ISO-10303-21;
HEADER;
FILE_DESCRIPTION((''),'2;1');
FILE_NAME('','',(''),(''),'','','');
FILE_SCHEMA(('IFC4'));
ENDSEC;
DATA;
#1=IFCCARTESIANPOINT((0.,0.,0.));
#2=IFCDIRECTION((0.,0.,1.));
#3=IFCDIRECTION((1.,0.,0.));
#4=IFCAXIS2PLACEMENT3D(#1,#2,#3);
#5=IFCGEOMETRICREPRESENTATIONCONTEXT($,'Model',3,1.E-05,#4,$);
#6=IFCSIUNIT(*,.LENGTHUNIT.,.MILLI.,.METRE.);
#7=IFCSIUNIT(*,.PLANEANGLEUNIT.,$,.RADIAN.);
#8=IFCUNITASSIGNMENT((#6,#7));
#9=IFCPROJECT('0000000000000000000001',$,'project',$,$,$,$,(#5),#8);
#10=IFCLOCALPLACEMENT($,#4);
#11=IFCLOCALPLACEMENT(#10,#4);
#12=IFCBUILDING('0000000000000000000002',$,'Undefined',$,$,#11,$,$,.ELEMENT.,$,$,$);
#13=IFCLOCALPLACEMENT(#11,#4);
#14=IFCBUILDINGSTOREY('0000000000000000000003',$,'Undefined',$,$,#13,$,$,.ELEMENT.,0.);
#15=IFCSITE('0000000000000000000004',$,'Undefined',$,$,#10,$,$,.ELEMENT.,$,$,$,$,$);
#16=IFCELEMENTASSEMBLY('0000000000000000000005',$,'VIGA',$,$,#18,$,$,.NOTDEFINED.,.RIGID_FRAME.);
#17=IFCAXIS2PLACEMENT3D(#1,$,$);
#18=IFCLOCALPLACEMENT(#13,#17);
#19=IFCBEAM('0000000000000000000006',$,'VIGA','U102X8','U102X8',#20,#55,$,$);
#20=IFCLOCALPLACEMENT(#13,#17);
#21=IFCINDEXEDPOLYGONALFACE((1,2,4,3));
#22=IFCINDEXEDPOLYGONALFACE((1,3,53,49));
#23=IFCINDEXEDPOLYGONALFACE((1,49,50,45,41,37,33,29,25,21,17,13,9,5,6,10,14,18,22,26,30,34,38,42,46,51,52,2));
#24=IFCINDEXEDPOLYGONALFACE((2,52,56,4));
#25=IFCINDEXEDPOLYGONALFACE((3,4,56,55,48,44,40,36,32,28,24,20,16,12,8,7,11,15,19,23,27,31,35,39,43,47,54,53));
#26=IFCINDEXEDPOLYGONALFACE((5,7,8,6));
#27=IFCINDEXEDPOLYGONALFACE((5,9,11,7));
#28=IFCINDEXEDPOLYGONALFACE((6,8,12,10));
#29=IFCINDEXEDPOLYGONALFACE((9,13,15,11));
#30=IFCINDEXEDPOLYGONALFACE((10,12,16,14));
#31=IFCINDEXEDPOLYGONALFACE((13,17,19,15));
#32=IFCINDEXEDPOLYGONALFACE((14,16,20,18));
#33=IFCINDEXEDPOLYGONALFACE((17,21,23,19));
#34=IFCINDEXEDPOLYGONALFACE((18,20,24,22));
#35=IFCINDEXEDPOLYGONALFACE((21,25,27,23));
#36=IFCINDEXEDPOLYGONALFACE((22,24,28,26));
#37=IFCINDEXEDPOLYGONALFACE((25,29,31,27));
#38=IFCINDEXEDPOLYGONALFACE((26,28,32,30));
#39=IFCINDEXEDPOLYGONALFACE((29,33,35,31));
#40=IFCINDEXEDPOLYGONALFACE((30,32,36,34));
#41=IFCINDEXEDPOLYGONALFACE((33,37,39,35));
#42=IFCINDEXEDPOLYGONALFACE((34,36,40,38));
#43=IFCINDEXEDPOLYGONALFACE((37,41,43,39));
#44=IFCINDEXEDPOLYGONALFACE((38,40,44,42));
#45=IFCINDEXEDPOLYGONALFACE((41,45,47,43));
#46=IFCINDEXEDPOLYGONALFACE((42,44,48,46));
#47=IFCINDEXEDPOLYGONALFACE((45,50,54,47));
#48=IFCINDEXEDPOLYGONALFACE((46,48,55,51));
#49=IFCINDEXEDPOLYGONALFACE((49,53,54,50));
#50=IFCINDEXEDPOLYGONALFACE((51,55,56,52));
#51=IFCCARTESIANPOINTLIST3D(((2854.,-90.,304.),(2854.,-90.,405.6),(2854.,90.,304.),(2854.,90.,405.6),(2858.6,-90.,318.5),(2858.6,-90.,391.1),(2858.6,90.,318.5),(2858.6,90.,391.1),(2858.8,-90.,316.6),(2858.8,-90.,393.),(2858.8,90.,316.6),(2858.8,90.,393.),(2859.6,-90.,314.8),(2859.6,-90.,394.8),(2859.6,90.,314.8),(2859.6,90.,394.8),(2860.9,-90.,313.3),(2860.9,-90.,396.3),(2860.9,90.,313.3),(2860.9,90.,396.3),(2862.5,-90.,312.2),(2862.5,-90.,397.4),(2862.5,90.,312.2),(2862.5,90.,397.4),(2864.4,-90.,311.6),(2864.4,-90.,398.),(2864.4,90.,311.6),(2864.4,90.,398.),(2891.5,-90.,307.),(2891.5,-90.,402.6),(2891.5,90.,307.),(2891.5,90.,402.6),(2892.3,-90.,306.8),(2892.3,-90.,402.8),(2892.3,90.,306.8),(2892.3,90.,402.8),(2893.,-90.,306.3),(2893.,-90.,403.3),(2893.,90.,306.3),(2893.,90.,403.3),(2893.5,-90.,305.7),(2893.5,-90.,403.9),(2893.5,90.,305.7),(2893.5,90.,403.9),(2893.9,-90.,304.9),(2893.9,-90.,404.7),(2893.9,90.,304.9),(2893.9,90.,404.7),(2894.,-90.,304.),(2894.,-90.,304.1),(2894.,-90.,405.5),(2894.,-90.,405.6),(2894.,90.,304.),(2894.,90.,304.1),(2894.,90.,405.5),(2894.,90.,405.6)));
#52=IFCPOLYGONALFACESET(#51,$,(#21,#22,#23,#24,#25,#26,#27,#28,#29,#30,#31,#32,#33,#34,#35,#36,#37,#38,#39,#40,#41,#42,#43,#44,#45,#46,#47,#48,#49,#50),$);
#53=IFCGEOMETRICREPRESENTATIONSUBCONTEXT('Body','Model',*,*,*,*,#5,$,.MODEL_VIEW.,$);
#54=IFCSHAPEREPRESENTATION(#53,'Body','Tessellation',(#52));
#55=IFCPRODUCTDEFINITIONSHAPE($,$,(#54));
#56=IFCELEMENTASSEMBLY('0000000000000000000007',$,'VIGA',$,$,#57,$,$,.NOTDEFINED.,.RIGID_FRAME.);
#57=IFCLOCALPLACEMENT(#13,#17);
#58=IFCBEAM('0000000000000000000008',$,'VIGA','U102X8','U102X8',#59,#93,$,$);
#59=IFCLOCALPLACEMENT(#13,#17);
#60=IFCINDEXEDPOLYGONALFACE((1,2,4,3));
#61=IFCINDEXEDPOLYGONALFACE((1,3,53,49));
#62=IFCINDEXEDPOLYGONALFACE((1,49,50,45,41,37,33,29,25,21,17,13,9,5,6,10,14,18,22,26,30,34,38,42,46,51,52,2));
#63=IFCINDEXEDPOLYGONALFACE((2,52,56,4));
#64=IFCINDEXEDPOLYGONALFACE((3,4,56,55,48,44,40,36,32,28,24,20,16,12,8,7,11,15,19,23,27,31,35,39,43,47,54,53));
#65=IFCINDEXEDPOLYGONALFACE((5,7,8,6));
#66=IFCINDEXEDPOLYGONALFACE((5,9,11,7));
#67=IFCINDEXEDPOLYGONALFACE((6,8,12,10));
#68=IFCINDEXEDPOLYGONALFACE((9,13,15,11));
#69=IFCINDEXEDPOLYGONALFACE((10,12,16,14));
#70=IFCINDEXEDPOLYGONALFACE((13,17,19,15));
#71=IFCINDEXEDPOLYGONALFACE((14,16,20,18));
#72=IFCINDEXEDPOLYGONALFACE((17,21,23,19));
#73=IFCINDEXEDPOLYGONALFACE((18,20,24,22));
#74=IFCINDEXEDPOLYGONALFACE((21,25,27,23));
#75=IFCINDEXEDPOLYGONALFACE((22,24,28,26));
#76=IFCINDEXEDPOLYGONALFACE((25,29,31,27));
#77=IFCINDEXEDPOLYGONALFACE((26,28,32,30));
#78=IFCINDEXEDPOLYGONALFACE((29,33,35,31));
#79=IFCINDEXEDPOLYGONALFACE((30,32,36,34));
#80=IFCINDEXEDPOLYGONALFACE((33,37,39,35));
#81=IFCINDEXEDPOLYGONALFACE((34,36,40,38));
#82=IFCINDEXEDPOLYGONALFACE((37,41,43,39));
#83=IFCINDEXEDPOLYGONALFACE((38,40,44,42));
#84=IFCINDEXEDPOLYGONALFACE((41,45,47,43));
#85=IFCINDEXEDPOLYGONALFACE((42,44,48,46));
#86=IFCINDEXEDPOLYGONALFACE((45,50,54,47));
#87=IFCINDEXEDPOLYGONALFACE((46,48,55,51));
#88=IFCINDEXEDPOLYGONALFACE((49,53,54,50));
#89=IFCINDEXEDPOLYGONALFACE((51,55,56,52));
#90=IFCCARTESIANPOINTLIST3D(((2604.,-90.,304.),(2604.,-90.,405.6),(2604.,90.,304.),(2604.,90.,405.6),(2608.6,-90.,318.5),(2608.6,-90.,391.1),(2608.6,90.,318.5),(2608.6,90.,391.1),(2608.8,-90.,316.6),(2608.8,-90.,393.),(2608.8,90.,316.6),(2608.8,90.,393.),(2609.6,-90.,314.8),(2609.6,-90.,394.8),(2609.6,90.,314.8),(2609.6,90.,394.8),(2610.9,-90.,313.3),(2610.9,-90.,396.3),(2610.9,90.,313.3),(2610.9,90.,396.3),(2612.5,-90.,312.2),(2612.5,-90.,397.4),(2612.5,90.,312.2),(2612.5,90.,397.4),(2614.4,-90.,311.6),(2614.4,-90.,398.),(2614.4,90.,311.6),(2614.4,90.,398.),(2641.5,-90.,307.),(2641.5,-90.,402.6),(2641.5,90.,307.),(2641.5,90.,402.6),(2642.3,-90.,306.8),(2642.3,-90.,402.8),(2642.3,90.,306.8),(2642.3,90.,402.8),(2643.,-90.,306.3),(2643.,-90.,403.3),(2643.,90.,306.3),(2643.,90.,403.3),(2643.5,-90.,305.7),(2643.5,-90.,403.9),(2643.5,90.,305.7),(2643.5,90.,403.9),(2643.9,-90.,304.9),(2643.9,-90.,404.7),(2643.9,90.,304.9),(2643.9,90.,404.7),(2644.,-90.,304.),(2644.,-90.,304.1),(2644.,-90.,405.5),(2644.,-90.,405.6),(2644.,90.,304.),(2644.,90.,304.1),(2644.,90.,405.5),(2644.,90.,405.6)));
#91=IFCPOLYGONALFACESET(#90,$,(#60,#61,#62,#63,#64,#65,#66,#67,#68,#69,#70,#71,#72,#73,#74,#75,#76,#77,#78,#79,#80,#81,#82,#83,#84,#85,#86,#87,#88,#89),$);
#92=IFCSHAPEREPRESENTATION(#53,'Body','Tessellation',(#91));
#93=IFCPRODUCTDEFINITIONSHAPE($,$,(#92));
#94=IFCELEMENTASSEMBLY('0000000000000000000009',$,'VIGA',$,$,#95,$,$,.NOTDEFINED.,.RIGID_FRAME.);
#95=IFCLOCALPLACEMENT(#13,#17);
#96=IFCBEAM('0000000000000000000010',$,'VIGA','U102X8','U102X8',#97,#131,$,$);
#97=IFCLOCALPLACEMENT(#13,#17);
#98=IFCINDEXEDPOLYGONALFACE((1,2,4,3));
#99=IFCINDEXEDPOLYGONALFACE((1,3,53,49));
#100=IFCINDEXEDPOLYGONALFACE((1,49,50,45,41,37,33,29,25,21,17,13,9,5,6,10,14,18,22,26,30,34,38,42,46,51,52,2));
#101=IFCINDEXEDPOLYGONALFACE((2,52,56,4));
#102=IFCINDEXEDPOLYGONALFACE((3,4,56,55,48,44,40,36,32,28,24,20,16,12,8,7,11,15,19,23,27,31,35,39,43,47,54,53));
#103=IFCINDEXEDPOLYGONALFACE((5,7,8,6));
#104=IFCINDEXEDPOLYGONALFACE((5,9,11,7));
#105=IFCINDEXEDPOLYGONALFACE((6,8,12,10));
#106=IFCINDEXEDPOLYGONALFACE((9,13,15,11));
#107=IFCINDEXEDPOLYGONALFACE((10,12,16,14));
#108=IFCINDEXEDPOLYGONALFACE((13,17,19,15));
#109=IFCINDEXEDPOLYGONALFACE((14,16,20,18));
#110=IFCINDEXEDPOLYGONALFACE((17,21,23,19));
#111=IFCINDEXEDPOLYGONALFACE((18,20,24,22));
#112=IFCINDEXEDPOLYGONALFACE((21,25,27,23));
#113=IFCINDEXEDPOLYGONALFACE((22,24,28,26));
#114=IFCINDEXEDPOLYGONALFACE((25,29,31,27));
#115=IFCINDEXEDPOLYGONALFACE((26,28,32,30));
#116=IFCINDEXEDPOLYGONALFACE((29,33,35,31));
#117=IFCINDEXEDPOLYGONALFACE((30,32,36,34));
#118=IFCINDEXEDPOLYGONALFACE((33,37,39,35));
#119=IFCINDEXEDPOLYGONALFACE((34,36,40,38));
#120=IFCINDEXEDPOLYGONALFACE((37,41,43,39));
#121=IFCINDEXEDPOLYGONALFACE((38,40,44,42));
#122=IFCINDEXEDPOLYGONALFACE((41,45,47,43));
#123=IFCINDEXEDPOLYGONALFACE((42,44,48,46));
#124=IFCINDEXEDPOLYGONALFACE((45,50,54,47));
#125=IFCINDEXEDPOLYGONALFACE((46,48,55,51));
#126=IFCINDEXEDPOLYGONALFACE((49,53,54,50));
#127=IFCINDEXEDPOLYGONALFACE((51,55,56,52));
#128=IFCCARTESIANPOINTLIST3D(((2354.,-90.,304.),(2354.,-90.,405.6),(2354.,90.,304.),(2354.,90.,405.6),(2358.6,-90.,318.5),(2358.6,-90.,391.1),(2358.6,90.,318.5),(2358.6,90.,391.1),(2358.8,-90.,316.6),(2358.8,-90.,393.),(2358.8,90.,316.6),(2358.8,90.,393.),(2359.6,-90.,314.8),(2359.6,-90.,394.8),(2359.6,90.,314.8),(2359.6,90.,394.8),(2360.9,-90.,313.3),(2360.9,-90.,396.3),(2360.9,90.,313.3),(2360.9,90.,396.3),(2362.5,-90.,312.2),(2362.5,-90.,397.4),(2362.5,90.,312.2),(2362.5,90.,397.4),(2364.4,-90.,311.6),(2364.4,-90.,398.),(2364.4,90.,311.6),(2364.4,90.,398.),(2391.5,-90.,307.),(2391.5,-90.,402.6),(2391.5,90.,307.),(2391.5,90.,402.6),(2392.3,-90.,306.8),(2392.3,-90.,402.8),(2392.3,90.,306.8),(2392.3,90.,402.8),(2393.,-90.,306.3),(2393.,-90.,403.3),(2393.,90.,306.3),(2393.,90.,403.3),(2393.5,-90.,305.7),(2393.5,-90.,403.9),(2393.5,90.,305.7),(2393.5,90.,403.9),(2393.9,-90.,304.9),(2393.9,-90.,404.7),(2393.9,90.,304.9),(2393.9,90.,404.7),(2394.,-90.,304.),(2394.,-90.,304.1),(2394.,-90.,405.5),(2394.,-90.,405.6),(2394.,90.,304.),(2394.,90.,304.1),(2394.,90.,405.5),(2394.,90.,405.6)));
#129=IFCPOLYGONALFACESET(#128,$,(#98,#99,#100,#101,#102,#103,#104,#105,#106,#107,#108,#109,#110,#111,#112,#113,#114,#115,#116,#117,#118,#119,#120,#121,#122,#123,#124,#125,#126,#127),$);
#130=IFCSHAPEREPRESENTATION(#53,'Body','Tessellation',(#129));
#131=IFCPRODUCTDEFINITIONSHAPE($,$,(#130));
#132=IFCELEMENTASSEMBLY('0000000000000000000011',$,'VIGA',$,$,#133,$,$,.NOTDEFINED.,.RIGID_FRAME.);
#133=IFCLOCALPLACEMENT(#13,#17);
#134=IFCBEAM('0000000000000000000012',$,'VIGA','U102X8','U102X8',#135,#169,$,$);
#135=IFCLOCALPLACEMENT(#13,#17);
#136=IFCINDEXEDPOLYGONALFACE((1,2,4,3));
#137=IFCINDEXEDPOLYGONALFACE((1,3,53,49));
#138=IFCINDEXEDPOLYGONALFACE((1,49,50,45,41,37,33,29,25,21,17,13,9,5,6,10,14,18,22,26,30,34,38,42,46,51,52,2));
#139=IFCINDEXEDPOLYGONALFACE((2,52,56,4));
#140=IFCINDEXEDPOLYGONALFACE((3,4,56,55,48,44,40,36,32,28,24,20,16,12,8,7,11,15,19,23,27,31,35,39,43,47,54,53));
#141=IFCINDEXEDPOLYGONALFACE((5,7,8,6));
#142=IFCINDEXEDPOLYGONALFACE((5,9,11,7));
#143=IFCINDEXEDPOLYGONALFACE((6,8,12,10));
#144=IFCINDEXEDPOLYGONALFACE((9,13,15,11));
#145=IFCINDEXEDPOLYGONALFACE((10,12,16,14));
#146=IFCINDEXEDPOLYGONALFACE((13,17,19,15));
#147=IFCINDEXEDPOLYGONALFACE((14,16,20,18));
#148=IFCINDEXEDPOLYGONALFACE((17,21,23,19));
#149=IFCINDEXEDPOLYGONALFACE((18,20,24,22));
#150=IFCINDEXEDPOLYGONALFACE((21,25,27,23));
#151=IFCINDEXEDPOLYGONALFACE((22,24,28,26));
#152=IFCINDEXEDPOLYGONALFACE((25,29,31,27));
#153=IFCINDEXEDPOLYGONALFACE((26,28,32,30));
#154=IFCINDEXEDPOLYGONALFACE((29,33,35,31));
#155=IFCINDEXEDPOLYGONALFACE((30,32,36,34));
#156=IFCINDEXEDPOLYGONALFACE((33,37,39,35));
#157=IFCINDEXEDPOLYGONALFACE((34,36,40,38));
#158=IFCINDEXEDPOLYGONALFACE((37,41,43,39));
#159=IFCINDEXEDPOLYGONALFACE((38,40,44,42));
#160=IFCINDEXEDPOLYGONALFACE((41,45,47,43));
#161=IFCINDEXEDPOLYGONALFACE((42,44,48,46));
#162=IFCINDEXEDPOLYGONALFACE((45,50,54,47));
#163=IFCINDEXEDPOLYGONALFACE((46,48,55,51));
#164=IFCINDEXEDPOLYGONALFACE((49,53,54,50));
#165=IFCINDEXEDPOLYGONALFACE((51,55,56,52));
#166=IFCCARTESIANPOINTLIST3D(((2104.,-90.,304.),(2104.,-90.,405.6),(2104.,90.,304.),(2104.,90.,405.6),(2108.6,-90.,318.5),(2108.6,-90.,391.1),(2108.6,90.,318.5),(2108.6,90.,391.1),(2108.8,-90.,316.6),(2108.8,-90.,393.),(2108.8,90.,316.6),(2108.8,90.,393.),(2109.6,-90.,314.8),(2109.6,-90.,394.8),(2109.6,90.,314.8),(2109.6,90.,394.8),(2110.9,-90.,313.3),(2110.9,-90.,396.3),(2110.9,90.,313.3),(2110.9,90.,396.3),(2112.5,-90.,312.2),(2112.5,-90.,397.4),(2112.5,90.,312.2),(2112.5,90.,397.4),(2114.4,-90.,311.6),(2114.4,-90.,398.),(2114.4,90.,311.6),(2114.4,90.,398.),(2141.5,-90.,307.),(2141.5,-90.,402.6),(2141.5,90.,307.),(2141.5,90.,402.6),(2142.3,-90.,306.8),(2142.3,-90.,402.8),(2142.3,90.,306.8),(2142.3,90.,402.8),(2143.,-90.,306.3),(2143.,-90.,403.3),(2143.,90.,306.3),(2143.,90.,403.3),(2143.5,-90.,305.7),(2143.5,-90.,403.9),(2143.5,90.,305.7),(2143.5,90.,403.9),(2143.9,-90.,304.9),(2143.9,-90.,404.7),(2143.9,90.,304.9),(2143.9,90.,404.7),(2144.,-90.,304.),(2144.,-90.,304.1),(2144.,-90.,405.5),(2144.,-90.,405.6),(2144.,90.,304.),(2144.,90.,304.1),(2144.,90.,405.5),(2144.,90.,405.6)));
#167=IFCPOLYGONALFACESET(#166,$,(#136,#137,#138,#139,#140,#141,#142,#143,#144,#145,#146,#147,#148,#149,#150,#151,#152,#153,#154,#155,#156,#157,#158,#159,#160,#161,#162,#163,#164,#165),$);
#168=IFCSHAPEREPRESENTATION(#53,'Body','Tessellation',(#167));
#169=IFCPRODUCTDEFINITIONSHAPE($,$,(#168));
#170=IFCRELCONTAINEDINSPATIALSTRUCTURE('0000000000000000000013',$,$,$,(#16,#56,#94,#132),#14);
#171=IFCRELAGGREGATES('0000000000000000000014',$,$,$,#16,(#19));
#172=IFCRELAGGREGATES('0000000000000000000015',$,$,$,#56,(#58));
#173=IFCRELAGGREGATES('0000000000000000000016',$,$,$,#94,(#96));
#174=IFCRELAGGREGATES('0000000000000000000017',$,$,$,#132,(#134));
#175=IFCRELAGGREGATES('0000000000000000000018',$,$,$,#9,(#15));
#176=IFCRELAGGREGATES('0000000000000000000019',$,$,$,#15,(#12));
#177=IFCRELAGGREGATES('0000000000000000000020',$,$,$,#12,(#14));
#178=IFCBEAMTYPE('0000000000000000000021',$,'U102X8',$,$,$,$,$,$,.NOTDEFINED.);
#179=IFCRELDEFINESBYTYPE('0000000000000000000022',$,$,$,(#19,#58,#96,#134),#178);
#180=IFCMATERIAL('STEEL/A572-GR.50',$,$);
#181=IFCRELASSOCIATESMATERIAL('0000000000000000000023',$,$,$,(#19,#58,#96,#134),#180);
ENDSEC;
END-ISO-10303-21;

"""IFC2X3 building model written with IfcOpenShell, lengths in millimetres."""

from ifc_helpers import new_model, si_unit, frame, origin_with_axes, origin_2d_with_axis, place, context, subcontext, project, spatial, u_section, extrude, material, type_object, element, aggregate, save


model = new_model("IFC2X3")

# Units and contexts
model_context = context("Model", 3, precision=1e-05, world=origin_with_axes())
body_context = subcontext(model_context, "Body", "Model", "MODEL_VIEW")
ifc_project = project(units=[si_unit("LENGTHUNIT", "METRE", prefix="MILLI"), si_unit("PLANEANGLEUNIT", "RADIAN")], contexts=[model_context])

# Site, building, storey
site_placement = place(None, origin_with_axes())
site = spatial("IfcSite", under=ifc_project, at=site_placement, Name="Undefined", CompositionType="ELEMENT")
building_placement = place(site_placement, origin_with_axes())
building = spatial("IfcBuilding", under=site, at=building_placement, Name="Undefined", CompositionType="ELEMENT")
storey_placement = place(building_placement, origin_with_axes())
storey = spatial("IfcBuildingStorey", under=building, at=storey_placement, Name="Undefined", CompositionType="ELEMENT", Elevation=0.0)

# Element assemblies, beams
ifc_material_1 = material(Name="STEEL/A572-GR.50")
beam_type = type_object("IfcBeamType", Name="U102X8", PredefinedType="NOTDEFINED")
assembly_1_placement = place(storey_placement, origin_with_axes())
assembly_1 = element("IfcElementAssembly", 1, at=assembly_1_placement, inside=storey, Name="VIGA", AssemblyPlace="NOTDEFINED", PredefinedType="RIGID_FRAME")
beam_1_placement = place(assembly_1_placement, frame((2874.0, -90.0, 354.8), z_axis=(0.0, 0.0, 1.0), x_axis=(0.0, 1.0, 0.0)))
beam_1 = element("IfcBeam", 2, at=beam_1_placement, type_object=beam_type, material=ifc_material_1, Name="VIGA", Description="U102X8", ObjectType="U102X8", context=body_context, shape_type="SweptSolid", body=[
    extrude(u_section(Depth=101.6, FlangeWidth=40.0, WebThickness=4.6, FlangeThickness=6.0, FilletRadius=7.0, EdgeRadius=3.0, FlangeSlope=0.16839, at=origin_2d_with_axis()), frame((180.0, 0.0, 0.0), z_axis=(-1.0, 0.0, 0.0), x_axis=(0.0, -1.0, 0.0)), (0.0, 0.0, 1.0), 180.0),
])
aggregate(assembly_1, [beam_1])
assembly_2_placement = place(storey_placement, origin_with_axes())
assembly_2 = element("IfcElementAssembly", 3, at=assembly_2_placement, inside=storey, Name="VIGA", AssemblyPlace="NOTDEFINED", PredefinedType="RIGID_FRAME")
beam_2_placement = place(assembly_2_placement, frame((2624.0, -90.0, 354.8), z_axis=(0.0, 0.0, 1.0), x_axis=(0.0, 1.0, 0.0)))
beam_2 = element("IfcBeam", 4, at=beam_2_placement, type_object=beam_type, material=ifc_material_1, Name="VIGA", Description="U102X8", ObjectType="U102X8", context=body_context, shape_type="SweptSolid", body=[
    extrude(u_section(Depth=101.6, FlangeWidth=40.0, WebThickness=4.6, FlangeThickness=6.0, FilletRadius=7.0, EdgeRadius=3.0, FlangeSlope=0.16839, at=origin_2d_with_axis()), frame((180.0, 0.0, 0.0), z_axis=(-1.0, 0.0, 0.0), x_axis=(0.0, -1.0, 0.0)), (0.0, 0.0, 1.0), 180.0),
])
aggregate(assembly_2, [beam_2])
assembly_3_placement = place(storey_placement, origin_with_axes())
assembly_3 = element("IfcElementAssembly", 5, at=assembly_3_placement, inside=storey, Name="VIGA", AssemblyPlace="NOTDEFINED", PredefinedType="RIGID_FRAME")
beam_3_placement = place(assembly_3_placement, frame((2374.0, -90.0, 354.8), z_axis=(0.0, 0.0, 1.0), x_axis=(0.0, 1.0, 0.0)))
beam_3 = element("IfcBeam", 6, at=beam_3_placement, type_object=beam_type, material=ifc_material_1, Name="VIGA", Description="U102X8", ObjectType="U102X8", context=body_context, shape_type="SweptSolid", body=[
    extrude(u_section(Depth=101.6, FlangeWidth=40.0, WebThickness=4.6, FlangeThickness=6.0, FilletRadius=7.0, EdgeRadius=3.0, FlangeSlope=0.16839, at=origin_2d_with_axis()), frame((180.0, 0.0, 0.0), z_axis=(-1.0, 0.0, 0.0), x_axis=(0.0, -1.0, 0.0)), (0.0, 0.0, 1.0), 180.0),
])
aggregate(assembly_3, [beam_3])
assembly_4_placement = place(storey_placement, origin_with_axes())
assembly_4 = element("IfcElementAssembly", 7, at=assembly_4_placement, inside=storey, Name="VIGA", AssemblyPlace="NOTDEFINED", PredefinedType="RIGID_FRAME")
beam_4_placement = place(assembly_4_placement, frame((2124.0, -90.0, 354.8), z_axis=(0.0, 0.0, 1.0), x_axis=(0.0, 1.0, 0.0)))
beam_4 = element("IfcBeam", 8, at=beam_4_placement, type_object=beam_type, material=ifc_material_1, Name="VIGA", Description="U102X8", ObjectType="U102X8", context=body_context, shape_type="SweptSolid", body=[
    extrude(u_section(Depth=101.6, FlangeWidth=40.0, WebThickness=4.6, FlangeThickness=6.0, FilletRadius=7.0, EdgeRadius=3.0, FlangeSlope=0.16839, at=origin_2d_with_axis()), frame((180.0, 0.0, 0.0), z_axis=(-1.0, 0.0, 0.0), x_axis=(0.0, -1.0, 0.0)), (0.0, 0.0, 1.0), 180.0),
])
aggregate(assembly_4, [beam_4])

save(model, "model.ifc")
